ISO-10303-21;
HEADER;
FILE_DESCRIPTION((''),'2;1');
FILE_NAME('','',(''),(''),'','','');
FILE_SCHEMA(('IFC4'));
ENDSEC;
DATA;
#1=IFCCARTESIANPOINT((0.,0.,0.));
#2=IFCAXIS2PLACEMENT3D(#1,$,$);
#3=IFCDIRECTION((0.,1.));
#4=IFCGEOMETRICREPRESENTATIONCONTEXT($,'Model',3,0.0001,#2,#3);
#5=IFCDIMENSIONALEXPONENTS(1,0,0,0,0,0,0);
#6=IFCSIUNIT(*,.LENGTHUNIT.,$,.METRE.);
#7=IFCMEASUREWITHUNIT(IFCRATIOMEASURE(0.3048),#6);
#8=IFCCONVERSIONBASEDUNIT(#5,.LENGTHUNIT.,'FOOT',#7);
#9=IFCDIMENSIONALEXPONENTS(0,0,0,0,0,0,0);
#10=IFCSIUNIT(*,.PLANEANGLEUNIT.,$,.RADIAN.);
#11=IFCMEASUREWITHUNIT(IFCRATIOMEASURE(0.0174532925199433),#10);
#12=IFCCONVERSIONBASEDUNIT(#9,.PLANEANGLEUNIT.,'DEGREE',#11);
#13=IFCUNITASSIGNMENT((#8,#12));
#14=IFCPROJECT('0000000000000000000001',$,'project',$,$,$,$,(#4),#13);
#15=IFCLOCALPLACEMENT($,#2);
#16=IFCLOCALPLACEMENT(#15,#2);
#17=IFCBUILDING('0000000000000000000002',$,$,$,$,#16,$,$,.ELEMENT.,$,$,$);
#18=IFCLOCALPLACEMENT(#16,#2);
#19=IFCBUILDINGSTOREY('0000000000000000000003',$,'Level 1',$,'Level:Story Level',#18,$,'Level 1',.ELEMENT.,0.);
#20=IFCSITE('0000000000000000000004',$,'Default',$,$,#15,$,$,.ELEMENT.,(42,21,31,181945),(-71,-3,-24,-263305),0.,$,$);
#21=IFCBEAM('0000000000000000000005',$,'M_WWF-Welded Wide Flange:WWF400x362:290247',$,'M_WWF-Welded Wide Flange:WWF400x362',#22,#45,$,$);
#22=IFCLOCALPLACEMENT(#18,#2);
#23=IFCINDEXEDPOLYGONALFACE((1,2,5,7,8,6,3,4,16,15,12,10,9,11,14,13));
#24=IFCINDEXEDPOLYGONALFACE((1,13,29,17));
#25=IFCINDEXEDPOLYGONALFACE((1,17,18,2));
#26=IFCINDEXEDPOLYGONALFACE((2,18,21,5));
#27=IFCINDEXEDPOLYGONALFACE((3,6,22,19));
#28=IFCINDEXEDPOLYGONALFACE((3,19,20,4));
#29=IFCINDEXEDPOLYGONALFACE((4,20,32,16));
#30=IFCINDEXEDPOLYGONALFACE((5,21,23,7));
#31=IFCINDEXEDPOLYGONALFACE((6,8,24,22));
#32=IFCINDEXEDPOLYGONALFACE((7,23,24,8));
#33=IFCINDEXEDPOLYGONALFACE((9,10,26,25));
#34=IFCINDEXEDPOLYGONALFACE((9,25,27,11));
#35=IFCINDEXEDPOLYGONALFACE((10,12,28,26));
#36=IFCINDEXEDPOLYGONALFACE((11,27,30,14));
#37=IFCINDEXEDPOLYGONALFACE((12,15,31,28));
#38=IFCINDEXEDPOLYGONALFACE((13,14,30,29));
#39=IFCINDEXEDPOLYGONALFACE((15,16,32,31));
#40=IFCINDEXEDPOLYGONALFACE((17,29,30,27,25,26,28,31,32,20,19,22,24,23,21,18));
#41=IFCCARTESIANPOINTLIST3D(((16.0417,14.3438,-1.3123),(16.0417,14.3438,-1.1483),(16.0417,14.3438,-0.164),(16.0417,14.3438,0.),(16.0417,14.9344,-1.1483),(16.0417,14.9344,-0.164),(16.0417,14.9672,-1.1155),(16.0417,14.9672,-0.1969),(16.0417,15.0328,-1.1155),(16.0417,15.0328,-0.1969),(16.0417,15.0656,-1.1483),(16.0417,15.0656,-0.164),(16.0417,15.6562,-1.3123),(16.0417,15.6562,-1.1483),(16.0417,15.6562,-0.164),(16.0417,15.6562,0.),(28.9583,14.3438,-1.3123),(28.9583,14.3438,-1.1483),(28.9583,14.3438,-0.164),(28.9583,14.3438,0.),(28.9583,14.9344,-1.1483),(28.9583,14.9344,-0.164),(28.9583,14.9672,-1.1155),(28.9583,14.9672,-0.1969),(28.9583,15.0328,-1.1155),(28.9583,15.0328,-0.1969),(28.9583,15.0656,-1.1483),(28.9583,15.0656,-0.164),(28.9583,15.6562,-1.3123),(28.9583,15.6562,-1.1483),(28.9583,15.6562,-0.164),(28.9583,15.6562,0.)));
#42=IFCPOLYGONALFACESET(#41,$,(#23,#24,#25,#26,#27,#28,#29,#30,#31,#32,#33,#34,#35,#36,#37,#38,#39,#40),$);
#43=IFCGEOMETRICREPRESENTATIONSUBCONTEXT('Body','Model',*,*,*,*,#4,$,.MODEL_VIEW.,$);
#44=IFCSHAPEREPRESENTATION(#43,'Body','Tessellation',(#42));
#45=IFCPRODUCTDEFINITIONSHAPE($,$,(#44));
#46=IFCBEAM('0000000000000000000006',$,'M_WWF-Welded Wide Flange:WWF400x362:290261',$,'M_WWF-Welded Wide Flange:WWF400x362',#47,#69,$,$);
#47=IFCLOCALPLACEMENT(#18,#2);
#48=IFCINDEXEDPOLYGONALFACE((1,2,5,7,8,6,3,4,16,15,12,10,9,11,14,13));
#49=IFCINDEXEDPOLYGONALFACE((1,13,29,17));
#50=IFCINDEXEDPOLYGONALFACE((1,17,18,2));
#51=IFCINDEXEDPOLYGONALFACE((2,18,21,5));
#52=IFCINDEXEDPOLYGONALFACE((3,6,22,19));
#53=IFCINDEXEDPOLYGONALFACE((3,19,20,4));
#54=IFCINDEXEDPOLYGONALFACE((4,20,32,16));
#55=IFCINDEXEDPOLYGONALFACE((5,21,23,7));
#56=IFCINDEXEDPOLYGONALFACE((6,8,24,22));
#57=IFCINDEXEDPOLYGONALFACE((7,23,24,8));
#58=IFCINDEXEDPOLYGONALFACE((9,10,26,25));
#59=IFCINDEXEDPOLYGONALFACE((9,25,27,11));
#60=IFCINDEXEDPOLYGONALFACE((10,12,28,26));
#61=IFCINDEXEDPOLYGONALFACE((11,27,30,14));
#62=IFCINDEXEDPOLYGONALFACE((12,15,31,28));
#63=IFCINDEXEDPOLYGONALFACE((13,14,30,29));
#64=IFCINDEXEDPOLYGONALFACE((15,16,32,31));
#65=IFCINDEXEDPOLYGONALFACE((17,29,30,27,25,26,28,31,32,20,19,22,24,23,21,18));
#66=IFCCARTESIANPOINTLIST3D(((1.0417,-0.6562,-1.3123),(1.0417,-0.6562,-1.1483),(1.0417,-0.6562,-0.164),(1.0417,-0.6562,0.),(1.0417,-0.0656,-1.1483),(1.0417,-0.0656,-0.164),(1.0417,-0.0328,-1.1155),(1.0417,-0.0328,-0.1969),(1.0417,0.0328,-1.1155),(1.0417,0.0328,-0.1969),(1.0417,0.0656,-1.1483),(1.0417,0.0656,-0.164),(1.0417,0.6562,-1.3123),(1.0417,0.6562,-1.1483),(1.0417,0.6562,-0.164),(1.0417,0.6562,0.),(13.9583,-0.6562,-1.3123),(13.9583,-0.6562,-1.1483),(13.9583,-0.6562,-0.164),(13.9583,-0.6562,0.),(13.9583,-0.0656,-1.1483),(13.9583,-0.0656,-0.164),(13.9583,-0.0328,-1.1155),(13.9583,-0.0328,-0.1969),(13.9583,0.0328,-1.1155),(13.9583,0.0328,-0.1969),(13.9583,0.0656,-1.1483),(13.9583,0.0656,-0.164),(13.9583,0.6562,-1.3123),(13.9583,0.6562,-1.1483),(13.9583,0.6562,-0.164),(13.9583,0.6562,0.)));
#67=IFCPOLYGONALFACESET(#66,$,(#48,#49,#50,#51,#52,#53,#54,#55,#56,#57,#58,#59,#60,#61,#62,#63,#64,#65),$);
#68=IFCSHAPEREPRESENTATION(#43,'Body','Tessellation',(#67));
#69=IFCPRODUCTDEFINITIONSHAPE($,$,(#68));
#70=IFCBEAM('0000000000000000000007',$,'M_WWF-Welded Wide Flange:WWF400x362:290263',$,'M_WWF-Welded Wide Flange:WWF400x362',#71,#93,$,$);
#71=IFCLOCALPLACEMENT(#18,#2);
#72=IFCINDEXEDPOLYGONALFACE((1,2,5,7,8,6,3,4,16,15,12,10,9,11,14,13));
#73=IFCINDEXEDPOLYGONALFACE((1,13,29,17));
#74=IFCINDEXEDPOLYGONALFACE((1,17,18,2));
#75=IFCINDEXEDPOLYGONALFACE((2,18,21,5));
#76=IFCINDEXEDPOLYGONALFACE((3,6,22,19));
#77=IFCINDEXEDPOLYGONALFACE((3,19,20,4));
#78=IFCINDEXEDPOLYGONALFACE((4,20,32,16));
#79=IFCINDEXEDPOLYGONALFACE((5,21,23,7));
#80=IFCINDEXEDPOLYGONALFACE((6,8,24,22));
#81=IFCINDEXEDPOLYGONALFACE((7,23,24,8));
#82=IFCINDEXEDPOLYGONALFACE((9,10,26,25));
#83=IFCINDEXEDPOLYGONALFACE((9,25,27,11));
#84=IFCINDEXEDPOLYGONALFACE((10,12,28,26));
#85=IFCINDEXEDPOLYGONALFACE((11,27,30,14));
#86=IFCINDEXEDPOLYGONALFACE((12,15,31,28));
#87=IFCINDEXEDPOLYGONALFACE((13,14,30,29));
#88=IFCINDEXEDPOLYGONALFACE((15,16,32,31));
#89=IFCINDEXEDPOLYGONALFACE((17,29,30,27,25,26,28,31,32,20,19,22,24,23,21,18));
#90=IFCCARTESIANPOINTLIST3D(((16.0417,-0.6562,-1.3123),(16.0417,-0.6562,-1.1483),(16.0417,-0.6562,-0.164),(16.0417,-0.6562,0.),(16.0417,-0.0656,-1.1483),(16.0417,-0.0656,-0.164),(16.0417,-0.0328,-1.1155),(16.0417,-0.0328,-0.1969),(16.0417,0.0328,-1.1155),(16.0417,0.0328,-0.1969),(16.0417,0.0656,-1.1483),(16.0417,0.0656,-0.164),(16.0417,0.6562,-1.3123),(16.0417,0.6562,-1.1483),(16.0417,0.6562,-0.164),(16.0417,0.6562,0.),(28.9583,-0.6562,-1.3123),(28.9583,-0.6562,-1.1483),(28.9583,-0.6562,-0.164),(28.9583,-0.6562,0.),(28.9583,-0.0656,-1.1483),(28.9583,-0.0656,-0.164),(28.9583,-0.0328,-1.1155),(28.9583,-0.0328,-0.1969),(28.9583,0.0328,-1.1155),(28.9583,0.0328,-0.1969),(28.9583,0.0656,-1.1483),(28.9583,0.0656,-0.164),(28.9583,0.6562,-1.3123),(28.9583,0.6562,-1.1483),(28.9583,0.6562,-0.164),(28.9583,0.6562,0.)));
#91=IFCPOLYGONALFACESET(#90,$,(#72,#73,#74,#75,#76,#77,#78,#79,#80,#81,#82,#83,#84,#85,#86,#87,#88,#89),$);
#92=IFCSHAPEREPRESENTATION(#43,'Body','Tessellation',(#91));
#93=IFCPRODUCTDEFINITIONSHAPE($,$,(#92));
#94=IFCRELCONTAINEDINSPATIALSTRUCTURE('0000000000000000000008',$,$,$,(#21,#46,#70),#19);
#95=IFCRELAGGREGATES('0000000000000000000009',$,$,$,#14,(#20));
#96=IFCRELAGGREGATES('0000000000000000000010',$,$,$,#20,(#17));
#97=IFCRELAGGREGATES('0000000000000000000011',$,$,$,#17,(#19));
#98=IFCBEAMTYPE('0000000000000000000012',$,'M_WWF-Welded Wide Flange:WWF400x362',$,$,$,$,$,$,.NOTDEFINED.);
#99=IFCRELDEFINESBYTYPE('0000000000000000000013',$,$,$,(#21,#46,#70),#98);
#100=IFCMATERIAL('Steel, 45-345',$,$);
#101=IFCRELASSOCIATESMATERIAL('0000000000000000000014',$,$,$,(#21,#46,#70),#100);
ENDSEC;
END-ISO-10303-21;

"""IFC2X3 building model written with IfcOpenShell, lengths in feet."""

from ifc_helpers import new_model, entity, si_unit, converted_unit, direction, frame, origin, place, context, subcontext, project, spatial, polyline, outline, extrude, material, type_object, element, save


model = new_model("IFC2X3")

# Units and contexts
model_context = context("Model", 3, precision=0.0001, world=origin(), true_north=direction((0.0, 1.0)))
body_context = subcontext(model_context, "Body", "Model", "MODEL_VIEW")
ifc_project = project(units=[converted_unit("LENGTHUNIT", "FOOT", entity("IfcRatioMeasure", 0.3048), si_unit("LENGTHUNIT", "METRE"), dimensions=[1, 0, 0, 0, 0, 0, 0]), converted_unit("PLANEANGLEUNIT", "DEGREE", entity("IfcRatioMeasure", 0.0174532925199433), si_unit("PLANEANGLEUNIT", "RADIAN"), dimensions=[0, 0, 0, 0, 0, 0, 0])], contexts=[model_context])

# Site, building, storey
site_placement = place(None, origin())
site = spatial("IfcSite", under=ifc_project, at=site_placement, Name="Default", CompositionType="ELEMENT", RefLatitude=(42, 21, 31, 181945), RefLongitude=(-71, -3, -24, -263305), RefElevation=0.0)
building_placement = place(site_placement, origin())
building = spatial("IfcBuilding", under=site, at=building_placement, CompositionType="ELEMENT")
storey_placement = place(building_placement, origin())
storey = spatial("IfcBuildingStorey", under=building, at=storey_placement, Name="Level 1", ObjectType="Level:Story Level", LongName="Level 1", CompositionType="ELEMENT", Elevation=0.0)

# Shared definitions
ifc_material = material(Name="Steel, 45-345")

# Beams
beam_type = type_object("IfcBeamType", Name="M_WWF-Welded Wide Flange:WWF400x362", PredefinedType="NOTDEFINED")
beam_1_placement = place(storey_placement, frame((15.0, 15.0, 0.0)))
element("IfcBeam", 1, at=beam_1_placement, inside=storey, type_object=beam_type, material=ifc_material, Name="M_WWF-Welded Wide Flange:WWF400x362:290247", ObjectType="M_WWF-Welded Wide Flange:WWF400x362", context=body_context, shape_type="SweptSolid", body=[
    extrude(outline(polyline([(-0.6562, -0.6562), (-0.4921, -0.6562), (-0.4921, -0.0656), (-0.4593, -0.0328), (0.4593, -0.0328), (0.4921, -0.0656), (0.4921, -0.6562), (0.6562, -0.6562), (0.6562, 0.6562), (0.4921, 0.6562), (0.4921, 0.0656), (0.4593, 0.0328), (-0.4593, 0.0328), (-0.4921, 0.0656), (-0.4921, 0.6562), (-0.6562, 0.6562), (-0.6562, -0.6562)])), frame((1.0417, 0.0, -0.6562), z_axis=(1.0, 0.0, 0.0), x_axis=(0.0, 0.0, -1.0)), (0.0, 0.0, 1.0), 12.9167),
])
beam_2_placement = place(storey_placement, origin())
element("IfcBeam", 2, at=beam_2_placement, inside=storey, type_object=beam_type, material=ifc_material, Name="M_WWF-Welded Wide Flange:WWF400x362:290261", ObjectType="M_WWF-Welded Wide Flange:WWF400x362", context=body_context, shape_type="SweptSolid", body=[
    extrude(outline(polyline([(-0.6562, -0.6562), (-0.4921, -0.6562), (-0.4921, -0.0656), (-0.4593, -0.0328), (0.4593, -0.0328), (0.4921, -0.0656), (0.4921, -0.6562), (0.6562, -0.6562), (0.6562, 0.6562), (0.4921, 0.6562), (0.4921, 0.0656), (0.4593, 0.0328), (-0.4593, 0.0328), (-0.4921, 0.0656), (-0.4921, 0.6562), (-0.6562, 0.6562), (-0.6562, -0.6562)])), frame((1.0417, 0.0, -0.6562), z_axis=(1.0, 0.0, 0.0), x_axis=(0.0, 0.0, -1.0)), (0.0, 0.0, 1.0), 12.9167),
])
beam_3_placement = place(storey_placement, frame((15.0, 0.0, 0.0)))
element("IfcBeam", 3, at=beam_3_placement, inside=storey, type_object=beam_type, material=ifc_material, Name="M_WWF-Welded Wide Flange:WWF400x362:290263", ObjectType="M_WWF-Welded Wide Flange:WWF400x362", context=body_context, shape_type="SweptSolid", body=[
    extrude(outline(polyline([(-0.6562, -0.6562), (-0.4921, -0.6562), (-0.4921, -0.0656), (-0.4593, -0.0328), (0.4593, -0.0328), (0.4921, -0.0656), (0.4921, -0.6562), (0.6562, -0.6562), (0.6562, 0.6562), (0.4921, 0.6562), (0.4921, 0.0656), (0.4593, 0.0328), (-0.4593, 0.0328), (-0.4921, 0.0656), (-0.4921, 0.6562), (-0.6562, 0.6562), (-0.6562, -0.6562)])), frame((1.0417, 0.0, -0.6562), z_axis=(1.0, 0.0, 0.0), x_axis=(0.0, 0.0, -1.0)), (0.0, 0.0, 1.0), 12.9167),
])

save(model, "model.ifc")
